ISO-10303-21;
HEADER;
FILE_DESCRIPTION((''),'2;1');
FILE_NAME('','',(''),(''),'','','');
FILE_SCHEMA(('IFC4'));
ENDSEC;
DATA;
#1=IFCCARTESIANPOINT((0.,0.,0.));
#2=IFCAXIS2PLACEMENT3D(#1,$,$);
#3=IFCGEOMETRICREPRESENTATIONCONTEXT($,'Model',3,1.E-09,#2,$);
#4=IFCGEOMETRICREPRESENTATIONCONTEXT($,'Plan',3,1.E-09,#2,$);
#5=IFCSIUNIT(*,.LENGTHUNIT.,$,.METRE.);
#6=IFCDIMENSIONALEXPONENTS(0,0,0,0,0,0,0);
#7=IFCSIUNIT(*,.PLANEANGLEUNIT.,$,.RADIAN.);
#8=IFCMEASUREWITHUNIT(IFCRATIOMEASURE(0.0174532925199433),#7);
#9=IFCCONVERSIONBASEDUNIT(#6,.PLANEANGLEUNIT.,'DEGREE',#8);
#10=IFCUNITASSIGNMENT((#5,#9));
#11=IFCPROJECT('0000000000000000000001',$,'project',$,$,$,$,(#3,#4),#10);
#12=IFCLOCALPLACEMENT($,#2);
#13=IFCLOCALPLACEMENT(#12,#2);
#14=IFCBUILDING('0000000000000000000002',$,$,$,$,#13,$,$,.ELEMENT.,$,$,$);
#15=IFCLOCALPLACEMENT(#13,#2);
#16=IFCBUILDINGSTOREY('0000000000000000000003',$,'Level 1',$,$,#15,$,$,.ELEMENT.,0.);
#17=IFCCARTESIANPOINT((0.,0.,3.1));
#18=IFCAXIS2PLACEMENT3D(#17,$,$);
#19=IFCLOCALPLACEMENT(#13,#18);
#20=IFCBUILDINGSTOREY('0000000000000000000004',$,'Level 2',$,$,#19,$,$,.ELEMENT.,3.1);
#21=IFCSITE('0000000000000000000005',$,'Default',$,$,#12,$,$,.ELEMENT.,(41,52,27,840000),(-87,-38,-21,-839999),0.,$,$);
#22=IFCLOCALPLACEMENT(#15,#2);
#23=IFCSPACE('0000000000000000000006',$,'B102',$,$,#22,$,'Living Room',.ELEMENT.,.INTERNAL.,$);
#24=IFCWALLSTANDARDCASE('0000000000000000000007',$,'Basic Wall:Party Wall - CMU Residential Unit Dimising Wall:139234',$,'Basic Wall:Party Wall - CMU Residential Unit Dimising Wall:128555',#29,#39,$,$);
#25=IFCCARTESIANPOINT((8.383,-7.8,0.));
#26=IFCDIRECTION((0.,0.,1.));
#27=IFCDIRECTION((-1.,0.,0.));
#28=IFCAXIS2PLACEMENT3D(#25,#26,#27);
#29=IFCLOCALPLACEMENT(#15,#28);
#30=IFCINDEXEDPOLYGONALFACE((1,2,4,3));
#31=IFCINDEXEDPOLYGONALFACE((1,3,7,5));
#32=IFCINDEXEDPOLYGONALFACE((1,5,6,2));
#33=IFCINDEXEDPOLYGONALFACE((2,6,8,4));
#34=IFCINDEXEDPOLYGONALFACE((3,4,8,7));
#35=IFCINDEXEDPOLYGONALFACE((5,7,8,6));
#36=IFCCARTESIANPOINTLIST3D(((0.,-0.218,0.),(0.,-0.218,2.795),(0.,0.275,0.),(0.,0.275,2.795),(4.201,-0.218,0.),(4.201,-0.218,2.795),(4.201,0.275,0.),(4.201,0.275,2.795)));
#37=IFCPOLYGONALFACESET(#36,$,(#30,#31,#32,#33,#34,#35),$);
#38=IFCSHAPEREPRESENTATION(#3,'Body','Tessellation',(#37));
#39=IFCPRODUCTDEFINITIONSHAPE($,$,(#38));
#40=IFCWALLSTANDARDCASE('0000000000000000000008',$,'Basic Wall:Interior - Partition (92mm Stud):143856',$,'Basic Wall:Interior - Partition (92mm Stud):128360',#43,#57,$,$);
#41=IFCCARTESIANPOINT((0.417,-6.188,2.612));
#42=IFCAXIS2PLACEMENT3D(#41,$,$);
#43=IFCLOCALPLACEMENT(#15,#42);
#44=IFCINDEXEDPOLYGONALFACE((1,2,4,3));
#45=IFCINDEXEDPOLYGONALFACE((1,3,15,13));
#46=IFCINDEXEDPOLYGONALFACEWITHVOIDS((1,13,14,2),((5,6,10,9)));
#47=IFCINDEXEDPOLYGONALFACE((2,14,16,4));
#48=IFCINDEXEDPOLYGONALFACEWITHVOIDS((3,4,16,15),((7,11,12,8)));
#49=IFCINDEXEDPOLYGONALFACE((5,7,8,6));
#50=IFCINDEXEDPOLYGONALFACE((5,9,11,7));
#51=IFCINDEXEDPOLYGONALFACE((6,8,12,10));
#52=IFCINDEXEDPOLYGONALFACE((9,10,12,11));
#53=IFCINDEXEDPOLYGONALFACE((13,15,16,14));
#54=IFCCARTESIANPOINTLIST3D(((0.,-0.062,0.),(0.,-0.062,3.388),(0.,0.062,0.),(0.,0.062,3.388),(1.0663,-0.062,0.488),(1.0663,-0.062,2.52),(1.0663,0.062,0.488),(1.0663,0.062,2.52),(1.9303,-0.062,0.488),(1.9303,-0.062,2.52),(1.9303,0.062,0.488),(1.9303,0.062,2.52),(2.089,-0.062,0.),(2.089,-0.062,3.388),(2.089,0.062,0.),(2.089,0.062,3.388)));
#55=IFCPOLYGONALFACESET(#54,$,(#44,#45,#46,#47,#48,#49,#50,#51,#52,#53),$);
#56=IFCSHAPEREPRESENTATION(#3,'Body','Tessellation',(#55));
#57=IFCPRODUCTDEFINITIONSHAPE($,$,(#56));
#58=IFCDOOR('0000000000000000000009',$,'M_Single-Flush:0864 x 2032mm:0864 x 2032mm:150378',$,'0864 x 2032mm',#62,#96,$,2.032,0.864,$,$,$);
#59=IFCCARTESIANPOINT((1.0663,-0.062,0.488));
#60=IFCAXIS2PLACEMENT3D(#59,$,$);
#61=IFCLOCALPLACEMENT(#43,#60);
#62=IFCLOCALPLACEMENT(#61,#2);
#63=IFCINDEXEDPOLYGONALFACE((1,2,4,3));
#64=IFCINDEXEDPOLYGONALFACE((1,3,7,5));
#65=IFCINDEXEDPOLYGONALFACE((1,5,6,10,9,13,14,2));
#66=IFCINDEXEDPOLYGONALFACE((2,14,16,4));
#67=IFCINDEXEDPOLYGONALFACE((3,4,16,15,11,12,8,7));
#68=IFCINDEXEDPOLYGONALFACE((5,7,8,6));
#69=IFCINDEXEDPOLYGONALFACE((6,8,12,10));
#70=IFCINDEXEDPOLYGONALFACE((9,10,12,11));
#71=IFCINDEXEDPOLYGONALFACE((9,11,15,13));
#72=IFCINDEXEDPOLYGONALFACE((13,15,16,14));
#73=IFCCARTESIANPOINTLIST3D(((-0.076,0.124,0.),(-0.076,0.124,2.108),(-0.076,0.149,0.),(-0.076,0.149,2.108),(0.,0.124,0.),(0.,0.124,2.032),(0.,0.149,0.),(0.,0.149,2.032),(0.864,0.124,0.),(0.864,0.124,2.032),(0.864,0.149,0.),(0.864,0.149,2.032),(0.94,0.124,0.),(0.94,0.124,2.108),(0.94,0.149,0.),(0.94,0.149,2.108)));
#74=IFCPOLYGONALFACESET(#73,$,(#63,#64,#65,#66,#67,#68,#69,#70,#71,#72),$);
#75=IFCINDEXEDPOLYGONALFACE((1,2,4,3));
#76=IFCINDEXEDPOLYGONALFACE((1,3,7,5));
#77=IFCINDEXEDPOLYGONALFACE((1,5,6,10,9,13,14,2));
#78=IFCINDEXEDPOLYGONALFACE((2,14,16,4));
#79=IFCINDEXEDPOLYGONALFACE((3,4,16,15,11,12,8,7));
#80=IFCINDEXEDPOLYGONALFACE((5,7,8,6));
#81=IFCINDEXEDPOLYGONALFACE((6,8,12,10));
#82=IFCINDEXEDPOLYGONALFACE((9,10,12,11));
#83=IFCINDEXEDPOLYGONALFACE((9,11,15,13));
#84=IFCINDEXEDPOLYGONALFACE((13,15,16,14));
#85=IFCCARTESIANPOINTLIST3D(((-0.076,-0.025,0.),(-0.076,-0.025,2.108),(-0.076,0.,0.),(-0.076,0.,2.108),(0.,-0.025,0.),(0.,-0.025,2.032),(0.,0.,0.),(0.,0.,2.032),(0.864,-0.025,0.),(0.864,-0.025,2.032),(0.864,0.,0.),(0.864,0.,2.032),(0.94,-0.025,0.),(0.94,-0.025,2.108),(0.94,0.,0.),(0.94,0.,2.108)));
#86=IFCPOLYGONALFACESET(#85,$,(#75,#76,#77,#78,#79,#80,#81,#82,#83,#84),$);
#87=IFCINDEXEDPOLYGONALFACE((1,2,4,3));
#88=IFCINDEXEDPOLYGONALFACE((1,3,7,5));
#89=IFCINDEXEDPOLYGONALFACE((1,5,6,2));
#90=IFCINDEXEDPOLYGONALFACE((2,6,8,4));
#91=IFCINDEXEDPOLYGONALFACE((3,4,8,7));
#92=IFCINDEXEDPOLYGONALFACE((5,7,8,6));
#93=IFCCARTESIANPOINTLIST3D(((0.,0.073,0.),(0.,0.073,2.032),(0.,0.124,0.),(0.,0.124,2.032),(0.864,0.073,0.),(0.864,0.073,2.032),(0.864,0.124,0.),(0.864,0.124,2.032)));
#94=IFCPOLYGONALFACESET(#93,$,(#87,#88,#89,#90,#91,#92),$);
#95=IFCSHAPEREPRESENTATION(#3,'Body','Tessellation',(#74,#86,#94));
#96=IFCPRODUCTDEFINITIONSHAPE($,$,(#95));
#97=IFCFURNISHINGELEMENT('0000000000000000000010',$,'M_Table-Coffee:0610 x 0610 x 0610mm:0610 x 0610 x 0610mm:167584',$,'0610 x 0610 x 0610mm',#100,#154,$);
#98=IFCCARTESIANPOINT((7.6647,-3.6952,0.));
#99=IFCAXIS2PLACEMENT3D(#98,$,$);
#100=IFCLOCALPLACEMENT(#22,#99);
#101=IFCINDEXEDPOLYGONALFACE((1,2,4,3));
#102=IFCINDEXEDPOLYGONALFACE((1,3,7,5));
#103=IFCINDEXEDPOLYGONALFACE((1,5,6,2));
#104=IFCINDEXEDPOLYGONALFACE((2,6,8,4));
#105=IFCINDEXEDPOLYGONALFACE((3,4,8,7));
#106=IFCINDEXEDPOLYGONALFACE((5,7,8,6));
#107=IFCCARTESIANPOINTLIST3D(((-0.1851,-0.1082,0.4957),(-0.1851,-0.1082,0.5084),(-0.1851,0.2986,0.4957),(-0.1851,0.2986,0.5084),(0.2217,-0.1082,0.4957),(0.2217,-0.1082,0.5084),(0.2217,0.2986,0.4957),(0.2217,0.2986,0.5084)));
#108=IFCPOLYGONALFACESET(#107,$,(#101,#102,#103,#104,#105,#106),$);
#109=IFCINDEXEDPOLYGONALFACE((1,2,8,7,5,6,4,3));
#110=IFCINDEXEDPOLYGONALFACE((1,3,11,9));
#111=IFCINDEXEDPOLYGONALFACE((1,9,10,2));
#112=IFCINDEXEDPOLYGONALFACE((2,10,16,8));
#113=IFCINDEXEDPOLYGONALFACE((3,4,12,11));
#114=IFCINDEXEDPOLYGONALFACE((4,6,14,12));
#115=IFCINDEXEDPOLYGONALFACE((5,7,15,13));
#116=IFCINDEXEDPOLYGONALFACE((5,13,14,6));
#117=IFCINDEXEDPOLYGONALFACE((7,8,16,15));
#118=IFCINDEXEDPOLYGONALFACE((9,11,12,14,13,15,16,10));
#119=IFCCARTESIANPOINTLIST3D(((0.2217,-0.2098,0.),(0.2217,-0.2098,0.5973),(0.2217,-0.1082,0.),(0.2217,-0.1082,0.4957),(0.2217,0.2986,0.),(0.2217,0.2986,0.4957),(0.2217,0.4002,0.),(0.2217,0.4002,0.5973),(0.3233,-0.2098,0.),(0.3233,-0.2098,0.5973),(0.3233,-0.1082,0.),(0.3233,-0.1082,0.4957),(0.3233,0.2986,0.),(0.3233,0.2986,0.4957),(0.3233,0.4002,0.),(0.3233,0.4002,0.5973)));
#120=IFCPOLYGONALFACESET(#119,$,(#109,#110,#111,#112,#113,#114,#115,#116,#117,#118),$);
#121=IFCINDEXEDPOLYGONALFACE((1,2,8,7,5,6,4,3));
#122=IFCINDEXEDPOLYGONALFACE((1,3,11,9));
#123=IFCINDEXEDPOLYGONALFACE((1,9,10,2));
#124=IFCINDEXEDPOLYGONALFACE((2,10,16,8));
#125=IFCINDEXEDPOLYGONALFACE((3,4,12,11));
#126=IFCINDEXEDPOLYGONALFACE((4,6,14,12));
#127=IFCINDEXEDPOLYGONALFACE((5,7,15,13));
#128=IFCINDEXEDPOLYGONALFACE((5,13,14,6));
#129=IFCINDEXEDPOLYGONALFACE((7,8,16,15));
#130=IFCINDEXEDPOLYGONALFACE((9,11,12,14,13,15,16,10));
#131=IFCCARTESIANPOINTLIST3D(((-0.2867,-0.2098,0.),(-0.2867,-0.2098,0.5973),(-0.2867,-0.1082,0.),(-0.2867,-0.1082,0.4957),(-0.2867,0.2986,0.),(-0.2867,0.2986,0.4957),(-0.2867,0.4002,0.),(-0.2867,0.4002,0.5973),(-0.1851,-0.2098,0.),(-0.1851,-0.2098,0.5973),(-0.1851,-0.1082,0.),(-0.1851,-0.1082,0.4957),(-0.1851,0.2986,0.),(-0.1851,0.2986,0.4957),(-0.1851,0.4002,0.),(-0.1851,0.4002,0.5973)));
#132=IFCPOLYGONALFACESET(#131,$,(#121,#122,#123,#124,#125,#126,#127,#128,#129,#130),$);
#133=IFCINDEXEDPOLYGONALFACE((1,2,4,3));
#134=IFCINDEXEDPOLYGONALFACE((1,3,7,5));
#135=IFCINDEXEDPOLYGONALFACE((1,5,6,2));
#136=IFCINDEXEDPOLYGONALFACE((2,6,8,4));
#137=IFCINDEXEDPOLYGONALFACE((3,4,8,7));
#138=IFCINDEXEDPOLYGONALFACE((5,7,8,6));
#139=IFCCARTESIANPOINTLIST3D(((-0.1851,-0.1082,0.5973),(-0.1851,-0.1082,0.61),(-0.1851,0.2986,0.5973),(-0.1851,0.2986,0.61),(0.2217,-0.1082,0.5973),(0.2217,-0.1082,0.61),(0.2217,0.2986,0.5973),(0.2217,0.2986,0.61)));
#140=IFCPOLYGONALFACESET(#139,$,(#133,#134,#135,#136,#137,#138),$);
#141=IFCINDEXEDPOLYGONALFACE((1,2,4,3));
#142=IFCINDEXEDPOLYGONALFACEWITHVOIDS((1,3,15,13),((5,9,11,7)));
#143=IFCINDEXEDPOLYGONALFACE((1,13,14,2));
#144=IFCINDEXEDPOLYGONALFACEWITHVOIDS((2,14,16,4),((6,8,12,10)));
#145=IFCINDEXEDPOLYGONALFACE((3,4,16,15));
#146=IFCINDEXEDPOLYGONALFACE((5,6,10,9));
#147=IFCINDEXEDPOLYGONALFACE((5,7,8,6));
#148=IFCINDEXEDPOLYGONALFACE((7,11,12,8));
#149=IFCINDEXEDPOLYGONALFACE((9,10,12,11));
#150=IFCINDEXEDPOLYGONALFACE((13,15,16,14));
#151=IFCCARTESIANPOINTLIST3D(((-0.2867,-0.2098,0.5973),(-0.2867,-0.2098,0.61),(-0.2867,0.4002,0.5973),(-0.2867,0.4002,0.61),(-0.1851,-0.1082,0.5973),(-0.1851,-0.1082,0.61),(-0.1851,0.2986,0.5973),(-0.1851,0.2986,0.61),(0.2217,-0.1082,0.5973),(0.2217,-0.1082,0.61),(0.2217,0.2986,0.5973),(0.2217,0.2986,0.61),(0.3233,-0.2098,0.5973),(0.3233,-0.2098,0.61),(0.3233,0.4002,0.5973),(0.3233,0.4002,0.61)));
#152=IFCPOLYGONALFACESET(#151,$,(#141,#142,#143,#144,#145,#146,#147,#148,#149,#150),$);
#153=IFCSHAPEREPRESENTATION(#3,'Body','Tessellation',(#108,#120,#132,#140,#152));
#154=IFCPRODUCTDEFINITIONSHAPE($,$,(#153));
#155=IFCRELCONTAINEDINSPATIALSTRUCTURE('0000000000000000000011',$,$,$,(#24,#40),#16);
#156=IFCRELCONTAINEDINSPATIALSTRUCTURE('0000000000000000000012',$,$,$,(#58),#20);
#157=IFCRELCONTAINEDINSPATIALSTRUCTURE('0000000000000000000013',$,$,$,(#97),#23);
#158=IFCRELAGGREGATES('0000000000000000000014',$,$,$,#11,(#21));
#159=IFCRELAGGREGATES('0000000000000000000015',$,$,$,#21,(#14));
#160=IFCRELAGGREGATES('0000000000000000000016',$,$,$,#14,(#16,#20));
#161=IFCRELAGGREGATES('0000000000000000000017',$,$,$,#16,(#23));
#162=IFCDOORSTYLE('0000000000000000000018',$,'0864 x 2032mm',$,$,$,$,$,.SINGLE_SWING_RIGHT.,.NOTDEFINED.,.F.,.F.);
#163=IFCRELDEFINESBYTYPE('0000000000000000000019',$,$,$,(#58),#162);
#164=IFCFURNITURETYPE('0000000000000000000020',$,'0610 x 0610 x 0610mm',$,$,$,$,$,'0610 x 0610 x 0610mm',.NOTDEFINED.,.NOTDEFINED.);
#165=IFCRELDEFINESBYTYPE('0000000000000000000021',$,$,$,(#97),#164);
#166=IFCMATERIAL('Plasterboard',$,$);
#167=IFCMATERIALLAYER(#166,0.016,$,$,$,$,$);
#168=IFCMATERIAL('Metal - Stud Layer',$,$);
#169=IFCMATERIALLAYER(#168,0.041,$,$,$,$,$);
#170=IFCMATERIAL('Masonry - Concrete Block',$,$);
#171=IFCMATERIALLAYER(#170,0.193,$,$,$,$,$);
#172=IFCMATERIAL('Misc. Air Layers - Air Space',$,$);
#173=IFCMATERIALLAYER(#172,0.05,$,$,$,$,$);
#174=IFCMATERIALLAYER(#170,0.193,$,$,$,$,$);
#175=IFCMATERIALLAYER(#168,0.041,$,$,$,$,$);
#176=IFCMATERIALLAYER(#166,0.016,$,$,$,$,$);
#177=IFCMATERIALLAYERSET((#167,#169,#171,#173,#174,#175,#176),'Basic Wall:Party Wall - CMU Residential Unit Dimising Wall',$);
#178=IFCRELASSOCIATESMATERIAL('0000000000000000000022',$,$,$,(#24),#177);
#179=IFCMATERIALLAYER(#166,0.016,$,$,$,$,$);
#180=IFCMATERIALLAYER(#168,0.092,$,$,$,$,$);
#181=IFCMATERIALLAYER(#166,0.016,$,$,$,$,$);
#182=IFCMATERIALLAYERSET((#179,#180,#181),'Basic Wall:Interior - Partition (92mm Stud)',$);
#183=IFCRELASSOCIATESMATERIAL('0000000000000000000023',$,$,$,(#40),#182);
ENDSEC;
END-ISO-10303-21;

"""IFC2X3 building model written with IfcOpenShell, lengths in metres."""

from ifc_helpers import new_model, entity, si_unit, converted_unit, frame, frame_2d, origin, origin_2d_with_axis, place, context, project, spatial, polyline, rectangle, outline, extrude, clip, bounded_halfspace, source, transform, mapped, material, layer, layer_set, layer_usage, type_object, type_shapes, element, fill, save


model = new_model("IFC2X3")

# Units and contexts
model_context = context("Model", 3, precision=1e-09, world=origin())
plan_context = context("Plan", 3, precision=1e-09, world=origin())
ifc_project = project(units=[si_unit("LENGTHUNIT", "METRE"), converted_unit("PLANEANGLEUNIT", "DEGREE", entity("IfcRatioMeasure", 0.0174532925199433), si_unit("PLANEANGLEUNIT", "RADIAN"), dimensions=[0, 0, 0, 0, 0, 0, 0])], contexts=[model_context, plan_context])

# Site, building, storey
site_placement = place(None, origin())
site = spatial("IfcSite", under=ifc_project, at=site_placement, Name="Default", CompositionType="ELEMENT", RefLatitude=(41, 52, 27, 840000), RefLongitude=(-87, -38, -21, -839999), RefElevation=0.0)
building_placement = place(site_placement, origin())
building = spatial("IfcBuilding", under=site, at=building_placement, CompositionType="ELEMENT")
storey_1_placement = place(building_placement, origin())
storey_1 = spatial("IfcBuildingStorey", under=building, at=storey_1_placement, Name="Level 1", CompositionType="ELEMENT", Elevation=0.0)

# Shared definitions
ifc_material_1 = material(Name="Misc. Air Layers - Air Space")
ifc_material_2 = material(Name="Masonry - Concrete Block")
ifc_material_3 = material(Name="Metal - Stud Layer")
ifc_material_4 = material(Name="Plasterboard")

# Shared definitions
ifc_layer_1 = layer(ifc_material_4, 0.016)
ifc_layer_2 = layer(ifc_material_3, 0.092)
ifc_layer_3 = layer(ifc_material_4, 0.016)
ifc_layer_set_1 = layer_set([ifc_layer_1, ifc_layer_2, ifc_layer_3], Name="Basic Wall:Interior - Partition (92mm Stud)")

# Wall
ifc_layer_4 = layer(ifc_material_4, 0.016)
ifc_layer_5 = layer(ifc_material_3, 0.041)
ifc_layer_6 = layer(ifc_material_2, 0.193)
ifc_layer_7 = layer(ifc_material_1, 0.05)
ifc_layer_8 = layer(ifc_material_2, 0.193)
ifc_layer_9 = layer(ifc_material_3, 0.041)
ifc_layer_10 = layer(ifc_material_4, 0.016)
ifc_layer_set_2 = layer_set([ifc_layer_4, ifc_layer_5, ifc_layer_6, ifc_layer_7, ifc_layer_8, ifc_layer_9, ifc_layer_10], Name="Basic Wall:Party Wall - CMU Residential Unit Dimising Wall")
ifc_layer_usage_1 = layer_usage(ifc_layer_set_2, "AXIS2", "NEGATIVE", 0.275)
wall_1_placement = place(storey_1_placement, frame((8.383, -7.8, 0.0), z_axis=(0.0, 0.0, 1.0), x_axis=(-1.0, 0.0, 0.0)))
element("IfcWallStandardCase", 1, at=wall_1_placement, inside=storey_1, material=ifc_layer_usage_1, Name="Basic Wall:Party Wall - CMU Residential Unit Dimising Wall:139234", ObjectType="Basic Wall:Party Wall - CMU Residential Unit Dimising Wall:128555", context=model_context, shape_type="Clipping", body=[
    clip(clip(extrude(rectangle(XDim=4.201, YDim=0.55, at=frame_2d((2.1005, 0.0), x_axis=(-1.0, 0.0))), origin(), (0.0, 0.0, 1.0), 2.795), bounded_halfspace(frame((0.0, -0.218, 2.795), z_axis=(0.0, 1.0, 0.0), x_axis=(-1.0, 0.0, 0.0)), True, frame((0.0, -0.218, 2.795), z_axis=(0.0, 1.0, 0.0), x_axis=(-1.0, 0.0, 0.0)), polyline([(0.0, 0.0), (-3.708, 0.0), (-4.201, 0.0), (-4.201, -2.795), (0.0, -2.795), (0.0, 0.0)]))), bounded_halfspace(frame((4.201, 0.275, 0.0), z_axis=(-1.0, 0.0, 0.0), x_axis=(0.0, -1.0, 0.0)), True, frame((4.201, 0.275, 0.0), z_axis=(-1.0, 0.0, 0.0), x_axis=(0.0, -1.0, 0.0)), polyline([(0.0, 0.0), (0.493, 0.0), (0.493, 2.795), (0.0, 2.795), (0.0, 0.0)]))),
])

# Wall, opening
ifc_layer_usage_2 = layer_usage(ifc_layer_set_1, "AXIS2", "NEGATIVE", 0.062)
wall_2_placement = place(storey_1_placement, frame((0.417, -6.188, 2.612)))
wall_2 = element("IfcWallStandardCase", 2, at=wall_2_placement, inside=storey_1, material=ifc_layer_usage_2, Name="Basic Wall:Interior - Partition (92mm Stud):143856", ObjectType="Basic Wall:Interior - Partition (92mm Stud):128360", context=model_context, shape_type="SweptSolid", body=[
    extrude(rectangle(XDim=2.089, YDim=0.124, at=frame_2d((1.0445, 0.0), x_axis=(-1.0, 0.0))), origin(), (0.0, 0.0, 1.0), 3.388),
])
opening_1_placement = place(wall_2_placement, frame((1.0663, -0.062, 0.488)))
opening_1 = element("IfcOpeningElement", 3, at=opening_1_placement, cuts=wall_2, ObjectType="Opening", context=model_context, shape_type="SweptSolid", body=[
    extrude(rectangle(XDim=0.864, YDim=2.032, at=frame_2d((1.016, 0.432), x_axis=(0.0, 1.0))), frame((0.0, 0.0, 0.0), z_axis=(0.0, 1.0, 0.0), x_axis=(0.0, 0.0, 1.0)), (0.0, 0.0, 1.0), 0.124),
])

# Shared definitions
storey_2_placement = place(building_placement, frame((0.0, 0.0, 3.1)))
storey_2 = spatial("IfcBuildingStorey", under=building, at=storey_2_placement, Name="Level 2", CompositionType="ELEMENT", Elevation=3.1)

# Door
door_style_1 = type_object("IfcDoorStyle", Name="0864 x 2032mm", ConstructionType="NOTDEFINED", OperationType="SINGLE_SWING_RIGHT", ParameterTakesPrecedence=False, Sizeable=False)
shared_shape_1 = source(origin(), model_context, "Body", "SweptSolid", [
    extrude(outline(polyline([(-0.508, -1.073), (0.508, -1.073), (0.508, 1.035), (0.432, 1.035), (0.432, -0.997), (-0.432, -0.997), (-0.432, 1.035), (-0.508, 1.035), (-0.508, -1.073)])), frame((0.432, 0.124, 1.035), z_axis=(0.0, 1.0, 0.0), x_axis=(1.0, 0.0, 0.0)), (0.0, 0.0, 1.0), 0.025),
    extrude(outline(polyline([(-1.073, -0.508), (1.035, -0.508), (1.035, -0.432), (-0.997, -0.432), (-0.997, 0.432), (1.035, 0.432), (1.035, 0.508), (-1.073, 0.508), (-1.073, -0.508)])), frame((0.432, -0.025, 1.035), z_axis=(0.0, 1.0, 0.0), x_axis=(0.0, 0.0, -1.0)), (0.0, 0.0, 1.0), 0.025),
    extrude(rectangle(XDim=0.051, YDim=0.864, at=origin_2d_with_axis()), frame((0.432, 0.0985, 0.0), z_axis=(0.0, 0.0, 1.0), x_axis=(0.0, 1.0, 0.0)), (0.0, 0.0, 1.0), 2.032),
])
type_shapes(door_style_1, [shared_shape_1])
door_1_placement = place(opening_1_placement, origin())
door_1 = element("IfcDoor", 4, at=door_1_placement, inside=storey_2, type_object=door_style_1, Name="M_Single-Flush:0864 x 2032mm:0864 x 2032mm:150378", ObjectType="0864 x 2032mm", OverallHeight=2.032, OverallWidth=0.864, context=model_context, shape_type="MappedRepresentation", body=[
    mapped(shared_shape_1, transform((0.0, 0.0, 0.0), scale=1.0)),
])
fill(opening_1, door_1)

# Shared definitions
space_1_placement = place(storey_1_placement, origin())
space_1 = spatial("IfcSpace", under=storey_1, at=space_1_placement, Name="B102", LongName="Living Room", CompositionType="ELEMENT", InteriorOrExteriorSpace="INTERNAL")

# Furnishing element
furniture_type_1 = type_object("IfcFurnitureType", Name="0610 x 0610 x 0610mm", ElementType="0610 x 0610 x 0610mm", AssemblyPlace="NOTDEFINED")
shared_shape_2 = source(origin(), model_context, "Body", "SweptSolid", [
    extrude(rectangle(XDim=0.4068, YDim=0.4068, at=origin_2d_with_axis()), frame((0.0183, 0.0952, 0.4957), z_axis=(0.0, 0.0, 1.0), x_axis=(-1.0, 0.0, 0.0)), (0.0, 0.0, 1.0), 0.0127),
    extrude(outline(polyline([(-0.2732, -0.305), (0.324, -0.305), (0.324, 0.305), (-0.2732, 0.305), (-0.2732, 0.2034), (0.2225, 0.2034), (0.2225, -0.2034), (-0.2732, -0.2034), (-0.2732, -0.305)])), frame((0.2217, 0.0952, 0.2732), z_axis=(1.0, 0.0, 0.0), x_axis=(0.0, 0.0, 1.0)), (0.0, 0.0, 1.0), 0.1016),
    extrude(outline(polyline([(-0.305, -0.3241), (0.305, -0.3241), (0.305, 0.2733), (0.2034, 0.2733), (0.2034, -0.2224), (-0.2034, -0.2224), (-0.2034, 0.2733), (-0.305, 0.2733), (-0.305, -0.3241)])), frame((-0.2867, 0.0952, 0.2733), z_axis=(1.0, 0.0, 0.0), x_axis=(0.0, -1.0, 0.0)), (0.0, 0.0, 1.0), 0.1016),
    extrude(rectangle(XDim=0.4068, YDim=0.4068, at=origin_2d_with_axis()), frame((0.0183, 0.0952, 0.5973), z_axis=(0.0, 0.0, 1.0), x_axis=(-1.0, 0.0, 0.0)), (0.0, 0.0, 1.0), 0.0127),
    extrude(outline(polyline([(-0.305, -0.305), (0.305, -0.305), (0.305, 0.305), (-0.305, 0.305), (-0.305, -0.305)]), holes=[polyline([(-0.2034, -0.2034), (-0.2034, 0.2034), (0.2034, 0.2034), (0.2034, -0.2034), (-0.2034, -0.2034)])]), frame((0.0183, 0.0952, 0.5973), z_axis=(0.0, 0.0, 1.0), x_axis=(-1.0, 0.0, 0.0)), (0.0, 0.0, 1.0), 0.0127),
])
type_shapes(furniture_type_1, [shared_shape_2])
for number, where, name in (
    (5, (7.6647, -3.6952, 0.0), "M_Table-Coffee:0610 x 0610 x 0610mm:0610 x 0610 x 0610mm:167584"),
):
    element("IfcFurnishingElement", number, at=place(space_1_placement, frame(where)), inside=space_1, type_object=furniture_type_1, Name=name, ObjectType="0610 x 0610 x 0610mm", context=model_context, shape_type="MappedRepresentation", body=[
        mapped(shared_shape_2, transform((0.0, 0.0, 0.0), scale=1.0)),
    ])

save(model, "model.ifc")
